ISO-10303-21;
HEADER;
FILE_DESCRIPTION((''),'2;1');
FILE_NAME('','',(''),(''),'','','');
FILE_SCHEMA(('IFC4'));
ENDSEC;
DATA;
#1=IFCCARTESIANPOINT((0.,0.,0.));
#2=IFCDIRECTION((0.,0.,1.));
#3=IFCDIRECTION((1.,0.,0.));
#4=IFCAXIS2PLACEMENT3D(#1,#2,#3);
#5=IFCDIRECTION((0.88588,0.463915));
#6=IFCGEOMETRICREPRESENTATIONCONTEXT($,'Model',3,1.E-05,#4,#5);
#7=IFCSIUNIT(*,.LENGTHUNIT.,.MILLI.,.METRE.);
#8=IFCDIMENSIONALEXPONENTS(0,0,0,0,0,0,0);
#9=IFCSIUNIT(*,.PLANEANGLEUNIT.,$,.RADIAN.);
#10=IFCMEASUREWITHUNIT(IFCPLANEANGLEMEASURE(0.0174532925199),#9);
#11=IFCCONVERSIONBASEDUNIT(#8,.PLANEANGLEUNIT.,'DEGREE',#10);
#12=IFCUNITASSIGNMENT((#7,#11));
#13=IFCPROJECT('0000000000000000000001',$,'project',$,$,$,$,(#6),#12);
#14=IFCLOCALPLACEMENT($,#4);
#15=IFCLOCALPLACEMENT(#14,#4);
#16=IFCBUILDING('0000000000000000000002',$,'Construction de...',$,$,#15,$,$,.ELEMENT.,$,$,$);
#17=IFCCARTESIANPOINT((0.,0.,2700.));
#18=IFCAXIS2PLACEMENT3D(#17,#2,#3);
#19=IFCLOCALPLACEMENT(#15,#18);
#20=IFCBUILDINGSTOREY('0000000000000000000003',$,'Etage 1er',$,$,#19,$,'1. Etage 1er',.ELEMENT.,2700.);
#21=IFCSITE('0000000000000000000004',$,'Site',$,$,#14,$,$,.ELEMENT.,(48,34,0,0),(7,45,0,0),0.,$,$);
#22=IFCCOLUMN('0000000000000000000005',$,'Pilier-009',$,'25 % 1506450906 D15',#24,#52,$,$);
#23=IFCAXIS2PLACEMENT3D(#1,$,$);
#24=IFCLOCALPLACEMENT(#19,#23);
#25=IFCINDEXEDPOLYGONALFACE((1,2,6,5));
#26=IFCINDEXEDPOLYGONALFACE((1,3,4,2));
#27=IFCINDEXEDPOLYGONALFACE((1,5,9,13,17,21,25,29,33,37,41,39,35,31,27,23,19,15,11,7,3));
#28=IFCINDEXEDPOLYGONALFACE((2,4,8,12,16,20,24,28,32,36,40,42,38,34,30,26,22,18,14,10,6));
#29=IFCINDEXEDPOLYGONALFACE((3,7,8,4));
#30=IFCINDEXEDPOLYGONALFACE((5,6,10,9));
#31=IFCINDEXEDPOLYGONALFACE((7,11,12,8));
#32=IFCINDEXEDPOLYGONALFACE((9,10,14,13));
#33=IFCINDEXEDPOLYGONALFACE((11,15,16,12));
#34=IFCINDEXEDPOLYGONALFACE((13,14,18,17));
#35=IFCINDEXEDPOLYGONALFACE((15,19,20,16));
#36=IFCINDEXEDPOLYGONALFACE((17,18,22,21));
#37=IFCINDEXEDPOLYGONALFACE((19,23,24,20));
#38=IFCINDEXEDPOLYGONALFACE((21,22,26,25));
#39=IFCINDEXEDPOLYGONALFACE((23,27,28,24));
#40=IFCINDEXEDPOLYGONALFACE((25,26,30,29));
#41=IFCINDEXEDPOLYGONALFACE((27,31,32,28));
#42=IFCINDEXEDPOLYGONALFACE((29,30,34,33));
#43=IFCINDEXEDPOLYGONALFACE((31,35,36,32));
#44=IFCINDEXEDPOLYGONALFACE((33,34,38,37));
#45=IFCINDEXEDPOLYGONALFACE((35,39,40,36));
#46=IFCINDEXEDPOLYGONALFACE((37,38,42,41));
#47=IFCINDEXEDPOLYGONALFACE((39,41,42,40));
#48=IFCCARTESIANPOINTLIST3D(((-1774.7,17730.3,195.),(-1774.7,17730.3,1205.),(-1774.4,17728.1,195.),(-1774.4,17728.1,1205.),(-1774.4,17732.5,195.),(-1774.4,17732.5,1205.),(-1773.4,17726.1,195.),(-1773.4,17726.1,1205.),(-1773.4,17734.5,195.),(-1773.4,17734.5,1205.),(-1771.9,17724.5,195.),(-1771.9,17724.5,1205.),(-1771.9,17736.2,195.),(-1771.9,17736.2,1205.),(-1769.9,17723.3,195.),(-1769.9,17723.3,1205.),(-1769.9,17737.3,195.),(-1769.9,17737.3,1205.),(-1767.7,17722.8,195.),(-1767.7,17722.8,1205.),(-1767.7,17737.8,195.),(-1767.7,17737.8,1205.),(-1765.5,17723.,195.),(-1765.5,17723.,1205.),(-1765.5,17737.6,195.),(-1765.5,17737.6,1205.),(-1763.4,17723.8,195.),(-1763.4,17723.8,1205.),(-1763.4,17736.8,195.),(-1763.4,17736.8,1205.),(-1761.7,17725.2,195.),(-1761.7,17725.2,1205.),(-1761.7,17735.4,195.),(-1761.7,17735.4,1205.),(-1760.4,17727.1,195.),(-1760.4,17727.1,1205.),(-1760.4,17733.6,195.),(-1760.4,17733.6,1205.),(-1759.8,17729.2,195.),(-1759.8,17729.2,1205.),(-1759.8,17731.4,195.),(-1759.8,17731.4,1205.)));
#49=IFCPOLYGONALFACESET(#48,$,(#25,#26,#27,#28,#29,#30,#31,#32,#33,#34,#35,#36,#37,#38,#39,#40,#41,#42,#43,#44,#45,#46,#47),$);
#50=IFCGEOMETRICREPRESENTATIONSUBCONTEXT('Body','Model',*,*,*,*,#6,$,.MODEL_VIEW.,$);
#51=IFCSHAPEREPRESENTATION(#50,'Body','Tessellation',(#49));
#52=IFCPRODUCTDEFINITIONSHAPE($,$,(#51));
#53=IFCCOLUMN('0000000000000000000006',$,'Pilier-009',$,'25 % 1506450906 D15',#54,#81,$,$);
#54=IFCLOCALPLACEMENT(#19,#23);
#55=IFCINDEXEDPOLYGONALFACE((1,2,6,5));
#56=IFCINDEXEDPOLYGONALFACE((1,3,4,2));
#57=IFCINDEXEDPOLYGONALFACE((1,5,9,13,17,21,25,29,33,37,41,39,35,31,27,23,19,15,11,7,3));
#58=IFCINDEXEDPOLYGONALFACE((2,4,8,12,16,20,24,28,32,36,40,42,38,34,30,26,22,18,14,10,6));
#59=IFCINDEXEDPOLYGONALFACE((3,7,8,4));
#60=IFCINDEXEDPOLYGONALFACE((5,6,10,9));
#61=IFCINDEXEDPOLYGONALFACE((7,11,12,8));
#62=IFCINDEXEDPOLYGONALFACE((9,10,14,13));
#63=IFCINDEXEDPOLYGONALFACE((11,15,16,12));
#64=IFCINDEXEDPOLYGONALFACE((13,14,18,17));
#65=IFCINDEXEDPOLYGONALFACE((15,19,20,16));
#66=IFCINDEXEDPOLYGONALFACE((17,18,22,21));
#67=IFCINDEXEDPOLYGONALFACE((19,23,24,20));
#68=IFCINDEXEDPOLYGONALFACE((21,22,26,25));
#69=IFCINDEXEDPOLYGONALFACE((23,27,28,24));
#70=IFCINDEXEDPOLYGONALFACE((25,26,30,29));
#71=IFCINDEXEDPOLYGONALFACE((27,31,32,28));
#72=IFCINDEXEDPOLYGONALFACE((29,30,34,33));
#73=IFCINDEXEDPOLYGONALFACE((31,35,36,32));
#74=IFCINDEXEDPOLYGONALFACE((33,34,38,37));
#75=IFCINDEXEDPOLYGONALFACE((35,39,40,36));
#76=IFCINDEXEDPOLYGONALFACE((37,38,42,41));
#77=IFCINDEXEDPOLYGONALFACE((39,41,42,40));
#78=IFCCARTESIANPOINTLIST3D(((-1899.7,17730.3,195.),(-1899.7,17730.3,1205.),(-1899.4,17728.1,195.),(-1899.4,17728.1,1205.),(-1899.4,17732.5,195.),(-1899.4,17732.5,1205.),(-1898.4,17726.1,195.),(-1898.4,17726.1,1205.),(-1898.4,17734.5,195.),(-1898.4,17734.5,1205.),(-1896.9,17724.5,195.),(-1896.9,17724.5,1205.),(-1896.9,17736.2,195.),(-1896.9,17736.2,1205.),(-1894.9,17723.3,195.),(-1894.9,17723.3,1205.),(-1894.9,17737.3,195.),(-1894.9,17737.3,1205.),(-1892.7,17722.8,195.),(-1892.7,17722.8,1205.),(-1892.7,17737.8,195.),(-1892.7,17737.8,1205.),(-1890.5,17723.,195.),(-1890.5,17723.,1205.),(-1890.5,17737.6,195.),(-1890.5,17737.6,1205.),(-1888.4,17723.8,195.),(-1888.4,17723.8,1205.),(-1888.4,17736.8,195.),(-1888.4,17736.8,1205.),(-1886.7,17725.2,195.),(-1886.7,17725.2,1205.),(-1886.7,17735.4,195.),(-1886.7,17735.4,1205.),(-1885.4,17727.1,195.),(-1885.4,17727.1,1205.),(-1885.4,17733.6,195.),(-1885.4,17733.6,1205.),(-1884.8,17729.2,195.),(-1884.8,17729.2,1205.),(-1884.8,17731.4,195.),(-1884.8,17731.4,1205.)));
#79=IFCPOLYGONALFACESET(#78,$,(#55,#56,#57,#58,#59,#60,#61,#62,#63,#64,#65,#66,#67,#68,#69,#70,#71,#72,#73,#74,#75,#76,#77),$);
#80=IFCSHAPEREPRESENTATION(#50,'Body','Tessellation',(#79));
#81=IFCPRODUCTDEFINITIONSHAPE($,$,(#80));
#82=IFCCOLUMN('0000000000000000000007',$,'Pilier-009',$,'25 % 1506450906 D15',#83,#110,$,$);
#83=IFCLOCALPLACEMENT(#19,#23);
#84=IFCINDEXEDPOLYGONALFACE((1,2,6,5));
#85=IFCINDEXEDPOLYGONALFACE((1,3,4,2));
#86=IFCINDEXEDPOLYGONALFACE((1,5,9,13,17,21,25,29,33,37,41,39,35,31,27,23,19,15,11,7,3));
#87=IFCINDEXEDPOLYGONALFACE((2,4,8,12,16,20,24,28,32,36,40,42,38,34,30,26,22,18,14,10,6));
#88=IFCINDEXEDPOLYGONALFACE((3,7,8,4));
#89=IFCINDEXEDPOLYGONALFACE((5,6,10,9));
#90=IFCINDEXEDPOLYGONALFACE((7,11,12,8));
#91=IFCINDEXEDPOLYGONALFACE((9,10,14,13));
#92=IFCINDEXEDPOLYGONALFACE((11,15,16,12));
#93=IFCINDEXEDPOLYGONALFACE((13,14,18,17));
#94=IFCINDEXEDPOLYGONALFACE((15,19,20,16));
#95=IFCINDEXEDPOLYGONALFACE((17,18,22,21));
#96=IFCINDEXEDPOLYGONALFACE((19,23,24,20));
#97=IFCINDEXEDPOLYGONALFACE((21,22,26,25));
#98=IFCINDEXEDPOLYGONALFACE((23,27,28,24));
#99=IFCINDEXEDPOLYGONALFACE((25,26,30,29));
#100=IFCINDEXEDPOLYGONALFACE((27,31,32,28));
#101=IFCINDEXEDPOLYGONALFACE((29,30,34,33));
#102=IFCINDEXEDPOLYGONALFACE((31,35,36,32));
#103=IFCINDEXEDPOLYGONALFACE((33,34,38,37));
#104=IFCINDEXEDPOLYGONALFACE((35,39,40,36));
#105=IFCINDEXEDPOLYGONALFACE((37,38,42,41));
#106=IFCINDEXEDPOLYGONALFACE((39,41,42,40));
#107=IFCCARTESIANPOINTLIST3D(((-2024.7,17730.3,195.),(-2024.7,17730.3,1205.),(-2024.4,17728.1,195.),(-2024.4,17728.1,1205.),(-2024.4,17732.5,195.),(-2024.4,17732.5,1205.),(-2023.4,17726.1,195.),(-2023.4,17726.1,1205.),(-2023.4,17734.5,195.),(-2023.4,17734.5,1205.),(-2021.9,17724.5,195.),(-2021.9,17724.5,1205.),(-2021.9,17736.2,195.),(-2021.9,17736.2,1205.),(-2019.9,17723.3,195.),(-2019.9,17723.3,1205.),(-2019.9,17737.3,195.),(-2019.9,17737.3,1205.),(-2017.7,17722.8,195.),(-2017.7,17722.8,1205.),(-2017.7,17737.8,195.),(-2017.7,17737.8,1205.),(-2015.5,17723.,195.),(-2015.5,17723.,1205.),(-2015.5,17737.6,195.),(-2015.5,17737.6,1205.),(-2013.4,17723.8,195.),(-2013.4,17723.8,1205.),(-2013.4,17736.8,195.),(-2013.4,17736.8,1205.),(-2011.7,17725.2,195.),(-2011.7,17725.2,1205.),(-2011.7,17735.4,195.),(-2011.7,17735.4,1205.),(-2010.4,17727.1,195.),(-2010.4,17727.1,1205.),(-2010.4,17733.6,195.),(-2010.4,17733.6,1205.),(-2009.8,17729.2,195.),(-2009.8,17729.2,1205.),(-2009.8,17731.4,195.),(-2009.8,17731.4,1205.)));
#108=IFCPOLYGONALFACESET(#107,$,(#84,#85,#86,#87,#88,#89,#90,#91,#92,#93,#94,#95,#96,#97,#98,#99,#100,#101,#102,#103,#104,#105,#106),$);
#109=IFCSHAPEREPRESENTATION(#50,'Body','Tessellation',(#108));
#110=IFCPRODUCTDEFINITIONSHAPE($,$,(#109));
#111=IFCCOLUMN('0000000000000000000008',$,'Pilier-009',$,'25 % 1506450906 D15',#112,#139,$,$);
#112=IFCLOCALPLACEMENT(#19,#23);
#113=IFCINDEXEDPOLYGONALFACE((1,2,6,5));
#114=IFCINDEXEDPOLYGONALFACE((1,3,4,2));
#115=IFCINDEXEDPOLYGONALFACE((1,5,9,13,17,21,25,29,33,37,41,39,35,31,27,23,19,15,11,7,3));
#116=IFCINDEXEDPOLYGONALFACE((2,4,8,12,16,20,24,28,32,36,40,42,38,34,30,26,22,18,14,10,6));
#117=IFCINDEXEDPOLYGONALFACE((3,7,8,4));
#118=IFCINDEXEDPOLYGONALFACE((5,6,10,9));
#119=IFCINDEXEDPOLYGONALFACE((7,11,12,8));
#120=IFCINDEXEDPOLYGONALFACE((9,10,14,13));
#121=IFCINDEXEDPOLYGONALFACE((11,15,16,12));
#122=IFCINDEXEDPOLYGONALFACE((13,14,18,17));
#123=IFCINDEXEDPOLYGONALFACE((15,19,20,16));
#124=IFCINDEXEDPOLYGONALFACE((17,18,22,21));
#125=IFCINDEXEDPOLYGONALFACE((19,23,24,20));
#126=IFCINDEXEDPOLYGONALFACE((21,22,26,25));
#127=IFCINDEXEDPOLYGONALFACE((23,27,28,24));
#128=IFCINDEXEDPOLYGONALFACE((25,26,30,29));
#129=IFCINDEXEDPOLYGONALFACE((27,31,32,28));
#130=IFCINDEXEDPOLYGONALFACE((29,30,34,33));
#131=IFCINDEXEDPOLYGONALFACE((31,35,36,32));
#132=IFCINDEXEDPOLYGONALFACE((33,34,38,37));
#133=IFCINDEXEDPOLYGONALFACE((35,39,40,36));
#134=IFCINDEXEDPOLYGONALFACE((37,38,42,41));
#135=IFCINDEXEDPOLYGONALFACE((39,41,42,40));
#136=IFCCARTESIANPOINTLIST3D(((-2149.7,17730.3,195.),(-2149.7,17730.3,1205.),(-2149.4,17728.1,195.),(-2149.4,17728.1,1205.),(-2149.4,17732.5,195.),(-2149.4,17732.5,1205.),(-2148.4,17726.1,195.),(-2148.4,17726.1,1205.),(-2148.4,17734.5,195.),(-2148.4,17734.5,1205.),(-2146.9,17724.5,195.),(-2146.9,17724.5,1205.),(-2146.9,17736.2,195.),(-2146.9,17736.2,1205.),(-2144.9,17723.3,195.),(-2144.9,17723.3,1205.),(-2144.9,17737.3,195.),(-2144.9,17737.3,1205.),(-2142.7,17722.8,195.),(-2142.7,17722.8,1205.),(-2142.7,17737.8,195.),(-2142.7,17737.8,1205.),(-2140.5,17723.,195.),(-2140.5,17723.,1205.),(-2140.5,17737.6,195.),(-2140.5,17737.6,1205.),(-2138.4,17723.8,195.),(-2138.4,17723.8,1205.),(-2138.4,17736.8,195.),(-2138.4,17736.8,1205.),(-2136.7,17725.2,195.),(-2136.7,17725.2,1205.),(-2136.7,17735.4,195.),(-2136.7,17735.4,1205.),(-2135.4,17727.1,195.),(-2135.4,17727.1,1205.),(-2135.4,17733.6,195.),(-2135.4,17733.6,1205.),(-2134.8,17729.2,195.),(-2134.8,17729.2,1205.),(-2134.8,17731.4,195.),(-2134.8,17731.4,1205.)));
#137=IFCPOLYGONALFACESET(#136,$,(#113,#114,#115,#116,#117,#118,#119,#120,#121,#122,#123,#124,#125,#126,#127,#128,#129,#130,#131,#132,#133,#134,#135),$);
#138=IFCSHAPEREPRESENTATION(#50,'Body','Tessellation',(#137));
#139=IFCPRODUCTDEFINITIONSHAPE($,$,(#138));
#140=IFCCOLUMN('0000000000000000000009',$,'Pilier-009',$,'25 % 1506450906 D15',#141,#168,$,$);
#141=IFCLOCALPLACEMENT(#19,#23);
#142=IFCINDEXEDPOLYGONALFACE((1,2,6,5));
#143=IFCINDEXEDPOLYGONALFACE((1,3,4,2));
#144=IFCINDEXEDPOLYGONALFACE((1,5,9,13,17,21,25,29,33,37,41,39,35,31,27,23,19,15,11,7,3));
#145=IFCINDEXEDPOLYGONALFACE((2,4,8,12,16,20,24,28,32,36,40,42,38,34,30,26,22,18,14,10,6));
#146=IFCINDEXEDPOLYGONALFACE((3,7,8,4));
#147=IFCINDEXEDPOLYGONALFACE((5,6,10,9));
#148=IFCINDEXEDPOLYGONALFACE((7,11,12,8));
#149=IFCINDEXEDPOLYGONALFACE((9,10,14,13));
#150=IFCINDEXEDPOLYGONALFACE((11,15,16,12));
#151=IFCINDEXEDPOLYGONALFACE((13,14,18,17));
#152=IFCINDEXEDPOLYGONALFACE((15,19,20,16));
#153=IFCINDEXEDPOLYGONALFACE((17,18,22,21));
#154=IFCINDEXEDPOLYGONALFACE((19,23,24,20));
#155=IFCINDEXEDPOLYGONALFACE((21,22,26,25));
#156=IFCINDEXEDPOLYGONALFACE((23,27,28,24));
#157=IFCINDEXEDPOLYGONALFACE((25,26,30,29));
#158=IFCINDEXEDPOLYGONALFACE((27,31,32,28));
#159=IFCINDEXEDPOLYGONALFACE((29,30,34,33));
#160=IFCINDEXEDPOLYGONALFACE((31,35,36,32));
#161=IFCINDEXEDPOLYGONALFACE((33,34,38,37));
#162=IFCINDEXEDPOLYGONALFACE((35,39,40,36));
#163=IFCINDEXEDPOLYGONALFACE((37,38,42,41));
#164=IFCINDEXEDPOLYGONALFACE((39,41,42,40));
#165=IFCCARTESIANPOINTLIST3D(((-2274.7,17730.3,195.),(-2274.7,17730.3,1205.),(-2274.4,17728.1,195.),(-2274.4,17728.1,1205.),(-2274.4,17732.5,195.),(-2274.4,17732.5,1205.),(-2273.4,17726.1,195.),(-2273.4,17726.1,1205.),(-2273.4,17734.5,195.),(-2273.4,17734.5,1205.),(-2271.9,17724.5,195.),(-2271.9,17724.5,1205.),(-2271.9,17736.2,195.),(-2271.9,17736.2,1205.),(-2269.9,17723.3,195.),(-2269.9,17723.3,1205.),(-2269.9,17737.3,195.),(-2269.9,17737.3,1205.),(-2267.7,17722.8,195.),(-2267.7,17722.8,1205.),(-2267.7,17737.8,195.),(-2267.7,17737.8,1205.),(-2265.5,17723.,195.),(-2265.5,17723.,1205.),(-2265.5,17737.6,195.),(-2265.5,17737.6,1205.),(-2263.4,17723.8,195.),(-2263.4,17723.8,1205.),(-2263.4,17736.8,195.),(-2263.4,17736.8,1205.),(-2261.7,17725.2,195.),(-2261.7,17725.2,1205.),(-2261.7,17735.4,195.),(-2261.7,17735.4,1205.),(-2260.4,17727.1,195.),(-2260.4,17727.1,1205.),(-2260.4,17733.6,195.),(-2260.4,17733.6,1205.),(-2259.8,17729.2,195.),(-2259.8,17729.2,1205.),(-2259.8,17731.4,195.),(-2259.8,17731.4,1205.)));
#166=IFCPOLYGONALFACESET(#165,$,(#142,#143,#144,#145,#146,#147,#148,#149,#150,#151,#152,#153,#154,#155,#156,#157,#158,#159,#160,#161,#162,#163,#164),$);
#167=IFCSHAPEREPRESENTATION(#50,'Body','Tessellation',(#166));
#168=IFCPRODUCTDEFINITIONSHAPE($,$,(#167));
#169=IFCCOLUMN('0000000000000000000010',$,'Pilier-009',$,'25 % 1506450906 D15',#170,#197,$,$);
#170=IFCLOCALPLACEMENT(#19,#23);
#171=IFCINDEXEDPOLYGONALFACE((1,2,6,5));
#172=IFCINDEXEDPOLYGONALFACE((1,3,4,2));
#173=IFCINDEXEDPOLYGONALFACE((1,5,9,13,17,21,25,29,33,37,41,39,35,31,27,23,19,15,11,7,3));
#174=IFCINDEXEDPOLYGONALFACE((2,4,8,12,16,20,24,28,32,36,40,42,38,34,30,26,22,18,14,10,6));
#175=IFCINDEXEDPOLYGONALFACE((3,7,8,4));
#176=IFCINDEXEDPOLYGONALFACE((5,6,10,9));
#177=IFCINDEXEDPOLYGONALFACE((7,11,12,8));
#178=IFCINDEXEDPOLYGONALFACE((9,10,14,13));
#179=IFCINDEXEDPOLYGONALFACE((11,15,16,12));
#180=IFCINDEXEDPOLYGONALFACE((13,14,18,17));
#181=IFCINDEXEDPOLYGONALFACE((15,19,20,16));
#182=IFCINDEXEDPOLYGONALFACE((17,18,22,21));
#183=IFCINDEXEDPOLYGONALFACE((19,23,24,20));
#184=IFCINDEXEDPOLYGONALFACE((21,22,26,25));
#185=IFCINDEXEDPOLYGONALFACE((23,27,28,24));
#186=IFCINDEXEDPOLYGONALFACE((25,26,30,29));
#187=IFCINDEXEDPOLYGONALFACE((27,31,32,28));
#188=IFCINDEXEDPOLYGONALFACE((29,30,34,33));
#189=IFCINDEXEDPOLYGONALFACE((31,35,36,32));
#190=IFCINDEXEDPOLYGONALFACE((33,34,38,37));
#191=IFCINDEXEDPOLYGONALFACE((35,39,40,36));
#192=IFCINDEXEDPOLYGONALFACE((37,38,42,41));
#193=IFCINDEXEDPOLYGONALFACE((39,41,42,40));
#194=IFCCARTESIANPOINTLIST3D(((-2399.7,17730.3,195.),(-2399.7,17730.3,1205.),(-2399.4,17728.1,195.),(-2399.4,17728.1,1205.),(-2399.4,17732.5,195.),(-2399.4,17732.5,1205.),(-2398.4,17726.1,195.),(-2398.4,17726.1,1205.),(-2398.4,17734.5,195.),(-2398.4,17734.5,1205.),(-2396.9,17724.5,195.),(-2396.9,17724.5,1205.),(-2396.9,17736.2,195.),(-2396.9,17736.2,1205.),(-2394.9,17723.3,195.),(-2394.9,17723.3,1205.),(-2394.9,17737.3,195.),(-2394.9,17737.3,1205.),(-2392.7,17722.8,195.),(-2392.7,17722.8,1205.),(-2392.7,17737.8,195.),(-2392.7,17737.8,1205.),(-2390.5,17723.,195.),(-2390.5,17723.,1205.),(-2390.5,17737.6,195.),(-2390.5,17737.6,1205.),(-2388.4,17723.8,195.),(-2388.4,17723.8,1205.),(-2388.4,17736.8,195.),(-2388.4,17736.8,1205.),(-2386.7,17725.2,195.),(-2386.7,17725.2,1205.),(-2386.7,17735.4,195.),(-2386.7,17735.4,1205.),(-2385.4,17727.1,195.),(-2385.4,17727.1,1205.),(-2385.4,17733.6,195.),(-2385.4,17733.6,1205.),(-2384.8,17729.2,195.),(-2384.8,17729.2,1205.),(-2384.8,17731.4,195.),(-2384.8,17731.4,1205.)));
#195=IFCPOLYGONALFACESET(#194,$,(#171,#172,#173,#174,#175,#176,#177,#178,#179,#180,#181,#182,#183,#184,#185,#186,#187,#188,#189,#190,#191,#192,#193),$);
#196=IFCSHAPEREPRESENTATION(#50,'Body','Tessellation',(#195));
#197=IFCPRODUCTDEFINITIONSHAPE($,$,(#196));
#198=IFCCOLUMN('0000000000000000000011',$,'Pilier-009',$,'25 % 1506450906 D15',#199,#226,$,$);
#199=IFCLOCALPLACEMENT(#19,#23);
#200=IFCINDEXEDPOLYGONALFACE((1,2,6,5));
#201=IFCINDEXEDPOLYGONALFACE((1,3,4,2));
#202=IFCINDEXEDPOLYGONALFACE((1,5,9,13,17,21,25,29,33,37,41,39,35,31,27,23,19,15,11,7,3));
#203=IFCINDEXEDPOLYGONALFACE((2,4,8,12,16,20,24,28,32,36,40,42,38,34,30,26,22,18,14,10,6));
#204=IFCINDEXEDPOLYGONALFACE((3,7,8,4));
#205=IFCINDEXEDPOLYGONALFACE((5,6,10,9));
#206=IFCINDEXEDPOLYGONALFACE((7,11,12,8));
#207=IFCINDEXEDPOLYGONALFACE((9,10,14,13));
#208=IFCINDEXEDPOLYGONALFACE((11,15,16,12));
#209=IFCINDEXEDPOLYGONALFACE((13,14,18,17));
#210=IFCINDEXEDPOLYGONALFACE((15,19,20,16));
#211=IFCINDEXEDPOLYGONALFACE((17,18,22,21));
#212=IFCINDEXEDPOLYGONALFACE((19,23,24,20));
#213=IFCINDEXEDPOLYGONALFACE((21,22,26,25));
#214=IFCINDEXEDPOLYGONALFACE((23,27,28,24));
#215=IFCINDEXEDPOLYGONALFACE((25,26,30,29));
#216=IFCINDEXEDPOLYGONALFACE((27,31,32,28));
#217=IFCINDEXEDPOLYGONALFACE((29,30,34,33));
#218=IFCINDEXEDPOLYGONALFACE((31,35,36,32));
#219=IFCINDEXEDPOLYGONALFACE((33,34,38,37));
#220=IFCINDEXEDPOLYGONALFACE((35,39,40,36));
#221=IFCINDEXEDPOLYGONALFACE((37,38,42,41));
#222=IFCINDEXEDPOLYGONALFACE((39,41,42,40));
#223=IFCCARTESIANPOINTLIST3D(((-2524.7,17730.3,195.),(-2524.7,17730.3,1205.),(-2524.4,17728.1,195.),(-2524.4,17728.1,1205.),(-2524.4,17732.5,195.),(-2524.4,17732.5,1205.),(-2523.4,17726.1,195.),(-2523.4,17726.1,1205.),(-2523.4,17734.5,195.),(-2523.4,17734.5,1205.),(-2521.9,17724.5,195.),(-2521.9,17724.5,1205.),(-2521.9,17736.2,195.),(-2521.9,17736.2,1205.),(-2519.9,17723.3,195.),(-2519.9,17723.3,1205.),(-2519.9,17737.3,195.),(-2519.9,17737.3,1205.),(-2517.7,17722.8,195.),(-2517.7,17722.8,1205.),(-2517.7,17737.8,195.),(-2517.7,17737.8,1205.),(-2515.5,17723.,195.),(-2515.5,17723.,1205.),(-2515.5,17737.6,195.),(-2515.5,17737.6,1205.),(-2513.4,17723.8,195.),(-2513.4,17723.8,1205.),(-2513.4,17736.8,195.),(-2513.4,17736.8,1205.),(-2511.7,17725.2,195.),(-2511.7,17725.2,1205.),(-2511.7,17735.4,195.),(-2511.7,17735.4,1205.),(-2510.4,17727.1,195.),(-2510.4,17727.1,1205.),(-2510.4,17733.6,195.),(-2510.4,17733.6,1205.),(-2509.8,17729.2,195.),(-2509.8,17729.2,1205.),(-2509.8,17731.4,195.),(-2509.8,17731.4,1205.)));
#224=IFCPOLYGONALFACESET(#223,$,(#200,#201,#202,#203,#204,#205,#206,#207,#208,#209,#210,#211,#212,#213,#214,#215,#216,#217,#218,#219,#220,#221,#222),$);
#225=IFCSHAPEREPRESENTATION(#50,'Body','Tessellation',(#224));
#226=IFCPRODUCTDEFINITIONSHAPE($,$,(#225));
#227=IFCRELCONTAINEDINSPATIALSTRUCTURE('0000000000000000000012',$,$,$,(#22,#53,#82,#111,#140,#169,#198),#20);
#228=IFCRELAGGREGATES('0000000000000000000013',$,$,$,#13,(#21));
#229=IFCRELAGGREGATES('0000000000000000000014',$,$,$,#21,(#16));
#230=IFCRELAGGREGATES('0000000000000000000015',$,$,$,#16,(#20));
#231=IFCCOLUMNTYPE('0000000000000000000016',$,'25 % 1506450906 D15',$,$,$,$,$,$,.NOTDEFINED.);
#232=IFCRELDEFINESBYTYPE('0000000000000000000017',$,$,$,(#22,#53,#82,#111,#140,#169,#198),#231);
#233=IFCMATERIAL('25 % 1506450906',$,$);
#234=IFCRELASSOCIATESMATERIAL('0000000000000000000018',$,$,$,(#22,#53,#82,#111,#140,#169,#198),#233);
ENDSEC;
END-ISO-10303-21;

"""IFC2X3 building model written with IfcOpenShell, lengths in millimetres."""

from ifc_helpers import new_model, entity, si_unit, converted_unit, direction, frame, origin_with_axes, origin_2d_with_axis, place, context, subcontext, project, spatial, circle, extrude, material, type_object, element, save


model = new_model("IFC2X3")

# Units and contexts
model_context = context("Model", 3, precision=1e-05, world=origin_with_axes(), true_north=direction((0.88588, 0.463915)))
body_context = subcontext(model_context, "Body", "Model", "MODEL_VIEW")
ifc_project = project(units=[si_unit("LENGTHUNIT", "METRE", prefix="MILLI"), converted_unit("PLANEANGLEUNIT", "DEGREE", entity("IfcPlaneAngleMeasure", 0.0174532925199), si_unit("PLANEANGLEUNIT", "RADIAN"), dimensions=[0, 0, 0, 0, 0, 0, 0])], contexts=[model_context])

# Site, building, storey
site_placement = place(None, origin_with_axes())
site = spatial("IfcSite", under=ifc_project, at=site_placement, Name="Site", CompositionType="ELEMENT", RefLatitude=(48, 34, 0, 0), RefLongitude=(7, 45, 0, 0), RefElevation=0.0)
building_placement = place(site_placement, origin_with_axes())
building = spatial("IfcBuilding", under=site, at=building_placement, Name="Construction de...", CompositionType="ELEMENT")
storey_placement = place(building_placement, frame((0.0, 0.0, 2700.0), z_axis=(0.0, 0.0, 1.0), x_axis=(1.0, 0.0, 0.0)))
storey = spatial("IfcBuildingStorey", under=building, at=storey_placement, Name="Etage 1er", LongName="1. Etage 1er", CompositionType="ELEMENT", Elevation=2700.0)

# Columns
ifc_material_1 = material(Name="25 % 1506450906")
column_type = type_object("IfcColumnType", Name="25 % 1506450906 D15", PredefinedType="NOTDEFINED")
for number, where, z_axis, x_axis, name in (
    (1, (-1767.2, 17730.3, 195.0), (0.0, 0.0, 1.0), (-1.0, 0.0, 0.0), "Pilier-009"),
    (2, (-1892.2, 17730.3, 195.0), (0.0, 0.0, 1.0), (-1.0, 0.0, 0.0), "Pilier-009"),
    (3, (-2017.2, 17730.3, 195.0), (0.0, 0.0, 1.0), (-1.0, 0.0, 0.0), "Pilier-009"),
    (4, (-2142.2, 17730.3, 195.0), (0.0, 0.0, 1.0), (-1.0, 0.0, 0.0), "Pilier-009"),
    (5, (-2267.2, 17730.3, 195.0), (0.0, 0.0, 1.0), (-1.0, 0.0, 0.0), "Pilier-009"),
    (6, (-2392.2, 17730.3, 195.0), (0.0, 0.0, 1.0), (-1.0, 0.0, 0.0), "Pilier-009"),
    (7, (-2517.2, 17730.3, 195.0), (0.0, 0.0, 1.0), (-1.0, 0.0, 0.0), "Pilier-009"),
):
    element("IfcColumn", number, at=place(storey_placement, frame(where, z_axis=z_axis, x_axis=x_axis)), inside=storey, type_object=column_type, material=ifc_material_1, Name=name, ObjectType="25 % 1506450906 D15", context=body_context, shape_type="SweptSolid", body=[
        extrude(circle(Radius=7.5, at=origin_2d_with_axis()), origin_with_axes(), (0.0, 0.0, 1.0), 1010.0),
    ])

save(model, "model.ifc")
